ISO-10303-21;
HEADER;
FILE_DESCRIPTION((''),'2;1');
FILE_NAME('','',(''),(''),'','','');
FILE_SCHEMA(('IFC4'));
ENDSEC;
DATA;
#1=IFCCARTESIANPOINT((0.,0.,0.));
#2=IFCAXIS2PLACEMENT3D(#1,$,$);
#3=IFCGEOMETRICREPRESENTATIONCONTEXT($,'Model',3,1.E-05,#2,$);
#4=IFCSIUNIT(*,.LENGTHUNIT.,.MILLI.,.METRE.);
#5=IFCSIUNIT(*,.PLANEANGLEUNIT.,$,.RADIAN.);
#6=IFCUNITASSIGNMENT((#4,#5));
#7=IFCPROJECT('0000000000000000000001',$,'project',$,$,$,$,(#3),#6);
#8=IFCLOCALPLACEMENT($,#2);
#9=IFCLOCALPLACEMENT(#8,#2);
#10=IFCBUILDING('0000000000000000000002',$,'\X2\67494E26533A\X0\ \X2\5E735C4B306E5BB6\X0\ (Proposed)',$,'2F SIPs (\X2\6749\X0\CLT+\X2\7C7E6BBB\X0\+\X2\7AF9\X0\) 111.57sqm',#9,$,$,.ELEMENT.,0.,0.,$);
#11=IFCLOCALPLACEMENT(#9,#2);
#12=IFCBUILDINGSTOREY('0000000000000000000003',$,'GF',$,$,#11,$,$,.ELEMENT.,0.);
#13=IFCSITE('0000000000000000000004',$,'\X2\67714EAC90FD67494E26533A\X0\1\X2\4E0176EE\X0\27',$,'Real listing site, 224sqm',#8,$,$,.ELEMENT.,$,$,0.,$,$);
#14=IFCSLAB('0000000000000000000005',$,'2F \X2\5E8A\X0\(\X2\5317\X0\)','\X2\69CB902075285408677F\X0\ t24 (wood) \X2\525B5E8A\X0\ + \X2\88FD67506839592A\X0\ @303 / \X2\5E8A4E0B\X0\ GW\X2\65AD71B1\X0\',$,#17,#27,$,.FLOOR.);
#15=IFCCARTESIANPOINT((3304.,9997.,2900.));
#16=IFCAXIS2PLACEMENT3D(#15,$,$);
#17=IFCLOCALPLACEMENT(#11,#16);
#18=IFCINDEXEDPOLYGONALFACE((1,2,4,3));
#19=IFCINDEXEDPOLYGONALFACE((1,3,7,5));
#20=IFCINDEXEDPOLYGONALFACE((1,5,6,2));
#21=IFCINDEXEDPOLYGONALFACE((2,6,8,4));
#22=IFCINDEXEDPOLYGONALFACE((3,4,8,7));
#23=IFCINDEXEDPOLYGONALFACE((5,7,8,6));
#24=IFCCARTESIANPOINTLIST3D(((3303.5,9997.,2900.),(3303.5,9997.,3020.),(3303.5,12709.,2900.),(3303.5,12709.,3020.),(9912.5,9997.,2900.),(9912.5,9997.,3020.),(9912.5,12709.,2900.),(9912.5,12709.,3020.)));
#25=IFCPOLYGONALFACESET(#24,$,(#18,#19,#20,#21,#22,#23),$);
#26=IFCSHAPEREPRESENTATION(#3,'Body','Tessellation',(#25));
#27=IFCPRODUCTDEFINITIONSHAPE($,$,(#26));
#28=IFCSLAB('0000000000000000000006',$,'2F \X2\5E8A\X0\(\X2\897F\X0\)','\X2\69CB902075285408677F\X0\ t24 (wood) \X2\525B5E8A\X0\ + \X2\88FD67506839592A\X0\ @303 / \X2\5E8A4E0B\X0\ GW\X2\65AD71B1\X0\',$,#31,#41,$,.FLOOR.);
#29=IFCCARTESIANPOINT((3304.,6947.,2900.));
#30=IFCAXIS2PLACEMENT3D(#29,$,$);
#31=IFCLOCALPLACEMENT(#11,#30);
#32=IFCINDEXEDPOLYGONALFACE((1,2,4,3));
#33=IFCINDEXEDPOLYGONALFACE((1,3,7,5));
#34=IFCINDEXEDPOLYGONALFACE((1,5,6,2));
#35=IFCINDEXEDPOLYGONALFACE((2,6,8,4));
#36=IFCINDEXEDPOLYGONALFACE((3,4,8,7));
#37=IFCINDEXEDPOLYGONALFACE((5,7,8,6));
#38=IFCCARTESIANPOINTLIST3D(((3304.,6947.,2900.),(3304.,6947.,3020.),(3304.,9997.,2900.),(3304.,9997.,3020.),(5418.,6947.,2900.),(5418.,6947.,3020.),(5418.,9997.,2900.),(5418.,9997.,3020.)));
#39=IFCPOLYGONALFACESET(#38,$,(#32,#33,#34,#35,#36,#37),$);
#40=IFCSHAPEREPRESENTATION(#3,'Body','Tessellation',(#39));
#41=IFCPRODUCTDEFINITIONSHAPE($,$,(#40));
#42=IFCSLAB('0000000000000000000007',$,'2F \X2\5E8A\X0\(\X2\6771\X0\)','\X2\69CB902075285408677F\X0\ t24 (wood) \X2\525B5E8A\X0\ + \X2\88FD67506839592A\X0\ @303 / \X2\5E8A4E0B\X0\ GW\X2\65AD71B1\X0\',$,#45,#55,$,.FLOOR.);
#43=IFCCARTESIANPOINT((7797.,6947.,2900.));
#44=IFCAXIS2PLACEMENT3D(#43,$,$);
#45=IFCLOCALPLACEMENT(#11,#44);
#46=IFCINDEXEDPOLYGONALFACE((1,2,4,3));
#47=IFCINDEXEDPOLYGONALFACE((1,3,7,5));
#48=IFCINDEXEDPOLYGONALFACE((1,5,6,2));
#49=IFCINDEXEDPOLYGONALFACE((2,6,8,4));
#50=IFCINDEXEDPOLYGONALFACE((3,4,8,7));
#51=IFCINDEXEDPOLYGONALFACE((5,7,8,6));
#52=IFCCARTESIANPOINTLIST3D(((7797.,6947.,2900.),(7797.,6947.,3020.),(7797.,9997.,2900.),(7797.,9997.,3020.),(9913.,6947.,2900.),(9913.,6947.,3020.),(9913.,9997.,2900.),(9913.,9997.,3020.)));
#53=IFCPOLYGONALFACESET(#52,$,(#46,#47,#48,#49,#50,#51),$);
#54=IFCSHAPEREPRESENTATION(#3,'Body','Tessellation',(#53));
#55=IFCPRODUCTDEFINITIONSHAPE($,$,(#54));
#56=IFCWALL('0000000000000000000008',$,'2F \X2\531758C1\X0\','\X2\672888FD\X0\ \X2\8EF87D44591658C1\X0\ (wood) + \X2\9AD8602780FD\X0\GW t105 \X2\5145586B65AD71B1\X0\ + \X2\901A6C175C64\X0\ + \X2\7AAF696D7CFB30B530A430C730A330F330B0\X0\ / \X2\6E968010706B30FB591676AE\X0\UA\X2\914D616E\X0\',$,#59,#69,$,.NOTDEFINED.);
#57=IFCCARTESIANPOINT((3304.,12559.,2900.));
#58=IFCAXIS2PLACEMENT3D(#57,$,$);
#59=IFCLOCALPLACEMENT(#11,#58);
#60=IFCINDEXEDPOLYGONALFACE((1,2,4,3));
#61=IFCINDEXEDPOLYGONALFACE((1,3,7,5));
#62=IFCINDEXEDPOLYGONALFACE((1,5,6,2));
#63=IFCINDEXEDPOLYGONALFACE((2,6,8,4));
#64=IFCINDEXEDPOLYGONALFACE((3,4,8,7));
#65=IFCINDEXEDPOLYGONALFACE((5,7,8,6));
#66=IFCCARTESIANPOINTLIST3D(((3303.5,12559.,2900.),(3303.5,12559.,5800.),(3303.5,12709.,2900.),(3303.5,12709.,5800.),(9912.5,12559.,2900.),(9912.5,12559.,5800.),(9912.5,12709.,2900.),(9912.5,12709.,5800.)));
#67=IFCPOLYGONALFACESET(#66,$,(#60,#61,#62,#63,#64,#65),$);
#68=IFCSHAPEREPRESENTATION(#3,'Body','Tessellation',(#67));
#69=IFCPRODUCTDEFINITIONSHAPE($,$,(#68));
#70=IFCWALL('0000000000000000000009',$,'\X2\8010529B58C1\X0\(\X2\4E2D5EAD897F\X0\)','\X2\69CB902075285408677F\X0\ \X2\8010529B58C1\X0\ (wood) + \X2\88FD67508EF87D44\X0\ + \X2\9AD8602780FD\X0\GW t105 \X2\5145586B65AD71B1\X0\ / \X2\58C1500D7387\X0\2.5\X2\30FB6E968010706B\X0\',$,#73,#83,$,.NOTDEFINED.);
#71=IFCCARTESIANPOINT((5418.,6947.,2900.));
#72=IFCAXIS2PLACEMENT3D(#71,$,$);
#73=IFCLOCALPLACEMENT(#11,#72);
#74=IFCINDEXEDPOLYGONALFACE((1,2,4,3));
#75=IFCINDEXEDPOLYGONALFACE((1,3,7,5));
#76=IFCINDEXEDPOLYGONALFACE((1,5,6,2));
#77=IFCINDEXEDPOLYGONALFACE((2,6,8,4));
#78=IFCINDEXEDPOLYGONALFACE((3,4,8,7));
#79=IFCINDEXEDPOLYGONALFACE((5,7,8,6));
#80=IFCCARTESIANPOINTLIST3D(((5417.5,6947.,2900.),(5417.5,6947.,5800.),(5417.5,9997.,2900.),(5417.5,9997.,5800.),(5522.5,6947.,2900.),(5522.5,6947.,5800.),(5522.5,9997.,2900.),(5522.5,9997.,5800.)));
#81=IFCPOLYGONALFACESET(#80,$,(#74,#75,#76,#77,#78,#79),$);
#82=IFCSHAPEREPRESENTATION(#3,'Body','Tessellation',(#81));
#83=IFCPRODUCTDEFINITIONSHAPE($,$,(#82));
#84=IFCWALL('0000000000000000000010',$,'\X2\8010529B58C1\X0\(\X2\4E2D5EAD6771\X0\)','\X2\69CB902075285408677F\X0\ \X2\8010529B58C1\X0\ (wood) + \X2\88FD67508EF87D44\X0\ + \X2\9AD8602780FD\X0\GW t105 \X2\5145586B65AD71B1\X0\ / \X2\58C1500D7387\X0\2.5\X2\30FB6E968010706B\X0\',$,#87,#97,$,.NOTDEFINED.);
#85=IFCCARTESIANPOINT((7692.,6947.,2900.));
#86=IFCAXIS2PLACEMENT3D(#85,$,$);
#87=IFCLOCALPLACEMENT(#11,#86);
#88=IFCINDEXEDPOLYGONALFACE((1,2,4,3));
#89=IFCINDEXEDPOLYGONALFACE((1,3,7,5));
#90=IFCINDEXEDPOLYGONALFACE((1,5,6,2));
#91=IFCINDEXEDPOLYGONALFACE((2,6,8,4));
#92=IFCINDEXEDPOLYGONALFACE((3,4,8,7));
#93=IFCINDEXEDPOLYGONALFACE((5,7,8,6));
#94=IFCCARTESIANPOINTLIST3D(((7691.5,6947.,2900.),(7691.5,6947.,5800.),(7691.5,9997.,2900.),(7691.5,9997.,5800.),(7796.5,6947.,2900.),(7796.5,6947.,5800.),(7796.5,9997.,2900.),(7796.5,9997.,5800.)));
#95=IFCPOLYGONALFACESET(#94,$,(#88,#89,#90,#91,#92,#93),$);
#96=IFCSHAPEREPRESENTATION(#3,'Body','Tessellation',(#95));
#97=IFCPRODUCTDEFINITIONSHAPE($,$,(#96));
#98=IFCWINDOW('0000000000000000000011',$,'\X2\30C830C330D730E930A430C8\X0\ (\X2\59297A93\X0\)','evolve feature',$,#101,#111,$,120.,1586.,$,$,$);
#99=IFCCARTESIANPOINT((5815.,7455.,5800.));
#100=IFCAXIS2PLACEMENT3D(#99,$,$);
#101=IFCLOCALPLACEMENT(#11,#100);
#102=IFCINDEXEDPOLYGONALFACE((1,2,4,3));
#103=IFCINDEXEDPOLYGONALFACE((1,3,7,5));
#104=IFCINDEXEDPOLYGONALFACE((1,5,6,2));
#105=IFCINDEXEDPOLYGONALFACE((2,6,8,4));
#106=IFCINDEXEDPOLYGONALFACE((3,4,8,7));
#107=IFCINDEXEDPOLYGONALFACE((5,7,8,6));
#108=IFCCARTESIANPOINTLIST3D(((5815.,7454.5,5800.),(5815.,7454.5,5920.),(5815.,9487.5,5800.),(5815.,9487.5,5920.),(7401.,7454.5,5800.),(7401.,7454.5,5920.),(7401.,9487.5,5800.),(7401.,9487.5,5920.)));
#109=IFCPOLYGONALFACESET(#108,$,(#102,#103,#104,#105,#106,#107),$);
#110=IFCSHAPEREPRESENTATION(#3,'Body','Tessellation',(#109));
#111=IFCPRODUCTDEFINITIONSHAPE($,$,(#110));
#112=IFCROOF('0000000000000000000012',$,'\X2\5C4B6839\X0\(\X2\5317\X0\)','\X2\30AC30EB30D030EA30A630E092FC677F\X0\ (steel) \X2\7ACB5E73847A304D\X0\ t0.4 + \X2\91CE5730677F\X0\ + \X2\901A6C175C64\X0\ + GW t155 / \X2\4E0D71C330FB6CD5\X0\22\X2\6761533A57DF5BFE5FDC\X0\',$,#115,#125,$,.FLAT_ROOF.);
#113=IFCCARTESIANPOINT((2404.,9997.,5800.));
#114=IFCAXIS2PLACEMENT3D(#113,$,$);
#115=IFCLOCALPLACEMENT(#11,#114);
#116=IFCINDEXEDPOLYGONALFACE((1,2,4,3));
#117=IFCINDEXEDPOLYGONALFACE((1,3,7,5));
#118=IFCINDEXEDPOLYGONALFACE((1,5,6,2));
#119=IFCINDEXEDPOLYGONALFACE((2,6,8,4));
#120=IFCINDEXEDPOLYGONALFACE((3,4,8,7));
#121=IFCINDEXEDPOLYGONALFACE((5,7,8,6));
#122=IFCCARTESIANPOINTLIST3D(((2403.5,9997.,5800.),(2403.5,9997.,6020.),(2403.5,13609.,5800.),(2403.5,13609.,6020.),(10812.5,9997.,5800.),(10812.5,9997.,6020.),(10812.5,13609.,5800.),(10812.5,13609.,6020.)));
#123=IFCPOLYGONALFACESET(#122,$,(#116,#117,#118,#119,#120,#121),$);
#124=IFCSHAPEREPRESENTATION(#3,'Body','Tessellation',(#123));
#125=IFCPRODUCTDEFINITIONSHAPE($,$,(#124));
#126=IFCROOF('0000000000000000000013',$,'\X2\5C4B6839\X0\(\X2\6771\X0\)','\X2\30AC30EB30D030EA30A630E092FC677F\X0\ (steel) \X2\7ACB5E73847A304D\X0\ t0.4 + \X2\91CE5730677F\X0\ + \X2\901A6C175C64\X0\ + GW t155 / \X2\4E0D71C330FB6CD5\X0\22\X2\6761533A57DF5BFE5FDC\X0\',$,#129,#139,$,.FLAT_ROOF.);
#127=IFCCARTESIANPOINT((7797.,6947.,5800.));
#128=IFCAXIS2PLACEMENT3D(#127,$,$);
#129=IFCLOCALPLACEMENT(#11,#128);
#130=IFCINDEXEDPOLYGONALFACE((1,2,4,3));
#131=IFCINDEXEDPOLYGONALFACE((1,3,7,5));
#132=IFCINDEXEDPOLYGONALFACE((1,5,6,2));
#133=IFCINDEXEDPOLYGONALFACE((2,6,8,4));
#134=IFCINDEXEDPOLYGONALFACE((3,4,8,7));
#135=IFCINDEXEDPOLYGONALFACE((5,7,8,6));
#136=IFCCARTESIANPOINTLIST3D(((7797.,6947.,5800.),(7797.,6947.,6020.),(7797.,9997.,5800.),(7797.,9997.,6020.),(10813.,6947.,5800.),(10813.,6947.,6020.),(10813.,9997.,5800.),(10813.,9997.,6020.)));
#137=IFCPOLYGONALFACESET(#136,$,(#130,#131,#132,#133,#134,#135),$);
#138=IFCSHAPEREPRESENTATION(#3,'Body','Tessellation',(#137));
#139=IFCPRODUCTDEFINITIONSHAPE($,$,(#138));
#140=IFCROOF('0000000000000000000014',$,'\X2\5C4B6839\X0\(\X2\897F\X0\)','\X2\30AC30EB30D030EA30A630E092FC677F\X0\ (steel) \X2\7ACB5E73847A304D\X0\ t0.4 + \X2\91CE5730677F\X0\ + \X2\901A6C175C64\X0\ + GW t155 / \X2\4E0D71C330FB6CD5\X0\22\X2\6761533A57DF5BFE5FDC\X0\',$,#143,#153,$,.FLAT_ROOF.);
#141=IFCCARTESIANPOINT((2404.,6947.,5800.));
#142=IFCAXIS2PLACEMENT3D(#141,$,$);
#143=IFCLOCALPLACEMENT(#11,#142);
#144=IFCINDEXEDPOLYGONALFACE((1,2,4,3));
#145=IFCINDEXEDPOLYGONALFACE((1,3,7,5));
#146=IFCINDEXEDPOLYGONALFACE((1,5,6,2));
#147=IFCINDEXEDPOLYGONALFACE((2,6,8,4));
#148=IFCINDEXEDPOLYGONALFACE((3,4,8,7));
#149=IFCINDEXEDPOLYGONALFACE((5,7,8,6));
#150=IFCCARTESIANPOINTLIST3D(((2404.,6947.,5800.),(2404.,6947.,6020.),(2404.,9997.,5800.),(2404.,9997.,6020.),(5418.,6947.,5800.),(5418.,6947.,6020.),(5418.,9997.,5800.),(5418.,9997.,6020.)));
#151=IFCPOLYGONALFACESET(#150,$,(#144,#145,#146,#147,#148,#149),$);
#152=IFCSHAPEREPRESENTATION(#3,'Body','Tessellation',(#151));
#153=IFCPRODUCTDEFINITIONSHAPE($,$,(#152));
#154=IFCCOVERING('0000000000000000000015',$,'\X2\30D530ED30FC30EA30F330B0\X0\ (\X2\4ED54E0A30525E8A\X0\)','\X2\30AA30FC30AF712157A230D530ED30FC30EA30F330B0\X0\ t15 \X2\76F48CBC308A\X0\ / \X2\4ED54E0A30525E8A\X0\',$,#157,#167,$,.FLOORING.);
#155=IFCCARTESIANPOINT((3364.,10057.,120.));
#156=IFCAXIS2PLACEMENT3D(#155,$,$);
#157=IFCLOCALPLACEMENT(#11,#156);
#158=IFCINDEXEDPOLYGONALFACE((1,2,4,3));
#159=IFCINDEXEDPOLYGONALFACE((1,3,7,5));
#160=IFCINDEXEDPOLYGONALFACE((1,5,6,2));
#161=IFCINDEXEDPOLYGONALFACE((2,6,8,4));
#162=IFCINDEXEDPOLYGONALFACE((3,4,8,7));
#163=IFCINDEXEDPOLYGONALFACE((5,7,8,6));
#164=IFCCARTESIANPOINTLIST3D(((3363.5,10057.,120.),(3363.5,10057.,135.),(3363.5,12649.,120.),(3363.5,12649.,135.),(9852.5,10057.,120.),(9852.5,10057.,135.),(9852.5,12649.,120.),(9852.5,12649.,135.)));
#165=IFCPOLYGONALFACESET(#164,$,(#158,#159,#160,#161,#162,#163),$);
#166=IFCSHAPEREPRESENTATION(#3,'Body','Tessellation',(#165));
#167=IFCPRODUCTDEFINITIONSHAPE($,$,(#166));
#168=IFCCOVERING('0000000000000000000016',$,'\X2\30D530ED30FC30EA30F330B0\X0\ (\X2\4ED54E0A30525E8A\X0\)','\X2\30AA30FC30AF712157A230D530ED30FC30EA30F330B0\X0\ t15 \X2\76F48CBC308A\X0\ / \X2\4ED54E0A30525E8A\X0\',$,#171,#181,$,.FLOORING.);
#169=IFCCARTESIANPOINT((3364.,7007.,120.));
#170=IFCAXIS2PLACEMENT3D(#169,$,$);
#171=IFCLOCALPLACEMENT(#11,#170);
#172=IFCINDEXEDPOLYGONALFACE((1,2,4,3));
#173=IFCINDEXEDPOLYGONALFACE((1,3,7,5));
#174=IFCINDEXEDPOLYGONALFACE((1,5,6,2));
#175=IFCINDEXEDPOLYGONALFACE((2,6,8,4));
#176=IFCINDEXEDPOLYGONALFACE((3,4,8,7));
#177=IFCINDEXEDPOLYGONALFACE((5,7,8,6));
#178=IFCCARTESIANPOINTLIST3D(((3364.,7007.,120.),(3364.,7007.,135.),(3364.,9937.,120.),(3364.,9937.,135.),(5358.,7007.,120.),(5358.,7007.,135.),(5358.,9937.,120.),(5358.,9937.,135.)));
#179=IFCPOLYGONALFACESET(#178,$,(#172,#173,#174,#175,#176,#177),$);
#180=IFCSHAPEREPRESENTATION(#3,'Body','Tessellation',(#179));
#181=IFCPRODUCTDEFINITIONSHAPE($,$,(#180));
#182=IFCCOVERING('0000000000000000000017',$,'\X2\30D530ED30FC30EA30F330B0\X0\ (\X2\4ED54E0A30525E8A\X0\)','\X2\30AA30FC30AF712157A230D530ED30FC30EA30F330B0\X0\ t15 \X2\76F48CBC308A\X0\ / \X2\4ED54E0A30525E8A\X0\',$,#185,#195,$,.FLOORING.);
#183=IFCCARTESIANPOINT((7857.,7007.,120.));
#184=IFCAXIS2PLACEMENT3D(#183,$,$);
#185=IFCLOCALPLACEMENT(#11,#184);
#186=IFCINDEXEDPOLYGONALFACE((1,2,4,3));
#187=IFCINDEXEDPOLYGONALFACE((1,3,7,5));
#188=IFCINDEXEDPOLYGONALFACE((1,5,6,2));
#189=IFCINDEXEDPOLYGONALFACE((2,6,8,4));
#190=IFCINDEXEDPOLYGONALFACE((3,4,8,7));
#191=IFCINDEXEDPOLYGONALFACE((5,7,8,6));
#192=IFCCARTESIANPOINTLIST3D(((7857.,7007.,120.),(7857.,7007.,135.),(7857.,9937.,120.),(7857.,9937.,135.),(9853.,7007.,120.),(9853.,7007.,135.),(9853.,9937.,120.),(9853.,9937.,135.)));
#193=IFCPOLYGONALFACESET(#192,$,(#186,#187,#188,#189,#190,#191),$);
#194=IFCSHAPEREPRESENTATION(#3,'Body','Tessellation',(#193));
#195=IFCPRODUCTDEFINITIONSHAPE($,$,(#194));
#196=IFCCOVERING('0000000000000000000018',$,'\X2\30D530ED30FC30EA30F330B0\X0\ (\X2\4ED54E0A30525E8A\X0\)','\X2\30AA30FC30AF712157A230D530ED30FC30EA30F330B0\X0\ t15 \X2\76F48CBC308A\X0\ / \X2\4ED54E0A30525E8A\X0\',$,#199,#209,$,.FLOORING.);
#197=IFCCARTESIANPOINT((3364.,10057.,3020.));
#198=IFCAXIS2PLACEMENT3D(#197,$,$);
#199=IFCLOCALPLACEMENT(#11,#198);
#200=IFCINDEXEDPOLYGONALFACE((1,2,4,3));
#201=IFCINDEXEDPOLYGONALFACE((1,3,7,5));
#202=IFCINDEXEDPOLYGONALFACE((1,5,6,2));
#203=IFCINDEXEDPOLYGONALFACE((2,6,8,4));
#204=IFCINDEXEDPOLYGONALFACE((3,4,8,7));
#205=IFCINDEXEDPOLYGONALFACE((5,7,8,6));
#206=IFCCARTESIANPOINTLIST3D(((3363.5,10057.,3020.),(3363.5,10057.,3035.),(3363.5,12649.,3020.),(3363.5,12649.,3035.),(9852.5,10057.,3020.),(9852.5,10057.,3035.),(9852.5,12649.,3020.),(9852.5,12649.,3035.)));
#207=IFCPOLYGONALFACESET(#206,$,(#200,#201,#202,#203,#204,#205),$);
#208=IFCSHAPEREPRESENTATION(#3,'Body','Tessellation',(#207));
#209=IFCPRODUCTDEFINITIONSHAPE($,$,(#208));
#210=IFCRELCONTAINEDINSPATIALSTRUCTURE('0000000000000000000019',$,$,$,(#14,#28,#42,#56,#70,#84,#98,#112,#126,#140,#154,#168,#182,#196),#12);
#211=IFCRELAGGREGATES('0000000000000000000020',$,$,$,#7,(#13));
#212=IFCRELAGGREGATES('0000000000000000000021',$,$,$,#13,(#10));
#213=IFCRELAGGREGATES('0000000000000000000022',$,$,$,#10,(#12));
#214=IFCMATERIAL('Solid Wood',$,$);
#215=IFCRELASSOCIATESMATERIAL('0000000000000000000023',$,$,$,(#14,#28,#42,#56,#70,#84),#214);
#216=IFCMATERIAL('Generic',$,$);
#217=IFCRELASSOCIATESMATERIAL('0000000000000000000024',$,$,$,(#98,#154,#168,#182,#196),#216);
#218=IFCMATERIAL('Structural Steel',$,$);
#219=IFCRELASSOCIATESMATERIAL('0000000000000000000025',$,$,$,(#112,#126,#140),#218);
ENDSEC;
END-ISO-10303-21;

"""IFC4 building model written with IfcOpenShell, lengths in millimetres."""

from ifc_helpers import new_model, si_unit, frame, frame_2d, origin, place, context, project, spatial, rectangle, extrude, material, element, save


model = new_model("IFC4")

# Units and contexts
model_context = context("Model", 3, precision=1e-05, world=origin())
ifc_project = project(units=[si_unit("LENGTHUNIT", "METRE", prefix="MILLI"), si_unit("PLANEANGLEUNIT", "RADIAN")], contexts=[model_context])

# Site, building, storey
site_placement = place(None, origin())
site = spatial("IfcSite", under=ifc_project, at=site_placement, Name="東京都杉並区1丁目27", ObjectType="Real listing site, 224sqm", CompositionType="ELEMENT", RefElevation=0.0)
building_placement = place(site_placement, origin())
building = spatial("IfcBuilding", under=site, at=building_placement, Name="杉並区 平屋の家 (Proposed)", ObjectType="2F SIPs (杉CLT+籾殻+竹) 111.57sqm", CompositionType="ELEMENT", ElevationOfRefHeight=0.0, ElevationOfTerrain=0.0)
storey_placement = place(building_placement, origin())
storey = spatial("IfcBuildingStorey", under=building, at=storey_placement, Name="GF", CompositionType="ELEMENT", Elevation=0.0)

# Slabs
ifc_material_1 = material(Name="Solid Wood")
slab_1_placement = place(storey_placement, frame((3304.0, 9997.0, 2900.0)))
element("IfcSlab", 1, at=slab_1_placement, inside=storey, material=ifc_material_1, Name="2F 床(北)", Description="構造用合板 t24 (wood) 剛床 + 製材根太 @303 / 床下 GW断熱", PredefinedType="FLOOR", context=model_context, shape_type="SweptSolid", body=[
    extrude(rectangle(XDim=6609.0, YDim=2712.0, at=frame_2d((3304.0, 1356.0))), frame((3304.0, 9997.0, 2900.0)), (0.0, 0.0, 1.0), 120.0),
])
slab_2_placement = place(storey_placement, frame((3304.0, 6947.0, 2900.0)))
element("IfcSlab", 2, at=slab_2_placement, inside=storey, material=ifc_material_1, Name="2F 床(西)", Description="構造用合板 t24 (wood) 剛床 + 製材根太 @303 / 床下 GW断熱", PredefinedType="FLOOR", context=model_context, shape_type="SweptSolid", body=[
    extrude(rectangle(XDim=2114.0, YDim=3050.0, at=frame_2d((1057.0, 1525.0))), frame((3304.0, 6947.0, 2900.0)), (0.0, 0.0, 1.0), 120.0),
])
slab_3_placement = place(storey_placement, frame((7797.0, 6947.0, 2900.0)))
element("IfcSlab", 3, at=slab_3_placement, inside=storey, material=ifc_material_1, Name="2F 床(東)", Description="構造用合板 t24 (wood) 剛床 + 製材根太 @303 / 床下 GW断熱", PredefinedType="FLOOR", context=model_context, shape_type="SweptSolid", body=[
    extrude(rectangle(XDim=2116.0, YDim=3050.0, at=frame_2d((1058.0, 1525.0))), frame((7797.0, 6947.0, 2900.0)), (0.0, 0.0, 1.0), 120.0),
])

# Wall
wall_1_placement = place(storey_placement, frame((3304.0, 12559.0, 2900.0)))
element("IfcWall", 4, at=wall_1_placement, inside=storey, material=ifc_material_1, Name="2F 北壁", Description="木製 軸組外壁 (wood) + 高性能GW t105 充填断熱 + 通気層 + 窯業系サイディング / 準耐火・外皮UA配慮", PredefinedType="NOTDEFINED", context=model_context, shape_type="SweptSolid", body=[
    extrude(rectangle(XDim=6609.0, YDim=150.0, at=frame_2d((3304.0, 75.0))), frame((3304.0, 12559.0, 2900.0)), (0.0, 0.0, 1.0), 2900.0),
])

# Walls
wall_2_placement = place(storey_placement, frame((5418.0, 6947.0, 2900.0)))
element("IfcWall", 5, at=wall_2_placement, inside=storey, material=ifc_material_1, Name="耐力壁(中庭西)", Description="構造用合板 耐力壁 (wood) + 製材軸組 + 高性能GW t105 充填断熱 / 壁倍率2.5・準耐火", PredefinedType="NOTDEFINED", context=model_context, shape_type="SweptSolid", body=[
    extrude(rectangle(XDim=105.0, YDim=3050.0, at=frame_2d((52.0, 1525.0))), frame((5418.0, 6947.0, 2900.0)), (0.0, 0.0, 1.0), 2900.0),
])
wall_3_placement = place(storey_placement, frame((7692.0, 6947.0, 2900.0)))
element("IfcWall", 6, at=wall_3_placement, inside=storey, material=ifc_material_1, Name="耐力壁(中庭東)", Description="構造用合板 耐力壁 (wood) + 製材軸組 + 高性能GW t105 充填断熱 / 壁倍率2.5・準耐火", PredefinedType="NOTDEFINED", context=model_context, shape_type="SweptSolid", body=[
    extrude(rectangle(XDim=105.0, YDim=3050.0, at=frame_2d((52.0, 1525.0))), frame((7692.0, 6947.0, 2900.0)), (0.0, 0.0, 1.0), 2900.0),
])

# Window
ifc_material_2 = material(Name="Generic")
window_1_placement = place(storey_placement, frame((5815.0, 7455.0, 5800.0)))
element("IfcWindow", 7, at=window_1_placement, inside=storey, material=ifc_material_2, Name="トップライト (天窓)", Description="evolve feature", OverallHeight=120.0, OverallWidth=1586.0, context=model_context, shape_type="SweptSolid", body=[
    extrude(rectangle(XDim=1586.0, YDim=2033.0, at=frame_2d((793.0, 1016.0))), frame((5815.0, 7455.0, 5800.0)), (0.0, 0.0, 1.0), 120.0),
])

# Roofs
ifc_material_3 = material(Name="Structural Steel")
roof_1_placement = place(storey_placement, frame((2404.0, 9997.0, 5800.0)))
element("IfcRoof", 8, at=roof_1_placement, inside=storey, material=ifc_material_3, Name="屋根(北)", Description="ガルバリウム鋼板 (steel) 立平葺き t0.4 + 野地板 + 通気層 + GW t155 / 不燃・法22条区域対応", PredefinedType="FLAT_ROOF", context=model_context, shape_type="SweptSolid", body=[
    extrude(rectangle(XDim=8409.0, YDim=3612.0, at=frame_2d((4204.0, 1806.0))), frame((2404.0, 9997.0, 5800.0)), (0.0, 0.0, 1.0), 220.0),
])
roof_2_placement = place(storey_placement, frame((7797.0, 6947.0, 5800.0)))
element("IfcRoof", 9, at=roof_2_placement, inside=storey, material=ifc_material_3, Name="屋根(東)", Description="ガルバリウム鋼板 (steel) 立平葺き t0.4 + 野地板 + 通気層 + GW t155 / 不燃・法22条区域対応", PredefinedType="FLAT_ROOF", context=model_context, shape_type="SweptSolid", body=[
    extrude(rectangle(XDim=3016.0, YDim=3050.0, at=frame_2d((1508.0, 1525.0))), frame((7797.0, 6947.0, 5800.0)), (0.0, 0.0, 1.0), 220.0),
])
roof_3_placement = place(storey_placement, frame((2404.0, 6947.0, 5800.0)))
element("IfcRoof", 10, at=roof_3_placement, inside=storey, material=ifc_material_3, Name="屋根(西)", Description="ガルバリウム鋼板 (steel) 立平葺き t0.4 + 野地板 + 通気層 + GW t155 / 不燃・法22条区域対応", PredefinedType="FLAT_ROOF", context=model_context, shape_type="SweptSolid", body=[
    extrude(rectangle(XDim=3014.0, YDim=3050.0, at=frame_2d((1507.0, 1525.0))), frame((2404.0, 6947.0, 5800.0)), (0.0, 0.0, 1.0), 220.0),
])

# Coverings
covering_1_placement = place(storey_placement, frame((3364.0, 10057.0, 120.0)))
element("IfcCovering", 11, at=covering_1_placement, inside=storey, material=ifc_material_2, Name="フローリング (仕上げ床)", Description="オーク無垢フローリング t15 直貼り / 仕上げ床", PredefinedType="FLOORING", context=model_context, shape_type="SweptSolid", body=[
    extrude(rectangle(XDim=6489.0, YDim=2592.0, at=frame_2d((3244.0, 1296.0))), frame((3364.0, 10057.0, 120.0)), (0.0, 0.0, 1.0), 15.0),
])
covering_2_placement = place(storey_placement, frame((3364.0, 7007.0, 120.0)))
element("IfcCovering", 12, at=covering_2_placement, inside=storey, material=ifc_material_2, Name="フローリング (仕上げ床)", Description="オーク無垢フローリング t15 直貼り / 仕上げ床", PredefinedType="FLOORING", context=model_context, shape_type="SweptSolid", body=[
    extrude(rectangle(XDim=1994.0, YDim=2930.0, at=frame_2d((997.0, 1465.0))), frame((3364.0, 7007.0, 120.0)), (0.0, 0.0, 1.0), 15.0),
])
covering_3_placement = place(storey_placement, frame((7857.0, 7007.0, 120.0)))
element("IfcCovering", 13, at=covering_3_placement, inside=storey, material=ifc_material_2, Name="フローリング (仕上げ床)", Description="オーク無垢フローリング t15 直貼り / 仕上げ床", PredefinedType="FLOORING", context=model_context, shape_type="SweptSolid", body=[
    extrude(rectangle(XDim=1996.0, YDim=2930.0, at=frame_2d((998.0, 1465.0))), frame((7857.0, 7007.0, 120.0)), (0.0, 0.0, 1.0), 15.0),
])
covering_4_placement = place(storey_placement, frame((3364.0, 10057.0, 3020.0)))
element("IfcCovering", 14, at=covering_4_placement, inside=storey, material=ifc_material_2, Name="フローリング (仕上げ床)", Description="オーク無垢フローリング t15 直貼り / 仕上げ床", PredefinedType="FLOORING", context=model_context, shape_type="SweptSolid", body=[
    extrude(rectangle(XDim=6489.0, YDim=2592.0, at=frame_2d((3244.0, 1296.0))), frame((3364.0, 10057.0, 3020.0)), (0.0, 0.0, 1.0), 15.0),
])

save(model, "model.ifc")
